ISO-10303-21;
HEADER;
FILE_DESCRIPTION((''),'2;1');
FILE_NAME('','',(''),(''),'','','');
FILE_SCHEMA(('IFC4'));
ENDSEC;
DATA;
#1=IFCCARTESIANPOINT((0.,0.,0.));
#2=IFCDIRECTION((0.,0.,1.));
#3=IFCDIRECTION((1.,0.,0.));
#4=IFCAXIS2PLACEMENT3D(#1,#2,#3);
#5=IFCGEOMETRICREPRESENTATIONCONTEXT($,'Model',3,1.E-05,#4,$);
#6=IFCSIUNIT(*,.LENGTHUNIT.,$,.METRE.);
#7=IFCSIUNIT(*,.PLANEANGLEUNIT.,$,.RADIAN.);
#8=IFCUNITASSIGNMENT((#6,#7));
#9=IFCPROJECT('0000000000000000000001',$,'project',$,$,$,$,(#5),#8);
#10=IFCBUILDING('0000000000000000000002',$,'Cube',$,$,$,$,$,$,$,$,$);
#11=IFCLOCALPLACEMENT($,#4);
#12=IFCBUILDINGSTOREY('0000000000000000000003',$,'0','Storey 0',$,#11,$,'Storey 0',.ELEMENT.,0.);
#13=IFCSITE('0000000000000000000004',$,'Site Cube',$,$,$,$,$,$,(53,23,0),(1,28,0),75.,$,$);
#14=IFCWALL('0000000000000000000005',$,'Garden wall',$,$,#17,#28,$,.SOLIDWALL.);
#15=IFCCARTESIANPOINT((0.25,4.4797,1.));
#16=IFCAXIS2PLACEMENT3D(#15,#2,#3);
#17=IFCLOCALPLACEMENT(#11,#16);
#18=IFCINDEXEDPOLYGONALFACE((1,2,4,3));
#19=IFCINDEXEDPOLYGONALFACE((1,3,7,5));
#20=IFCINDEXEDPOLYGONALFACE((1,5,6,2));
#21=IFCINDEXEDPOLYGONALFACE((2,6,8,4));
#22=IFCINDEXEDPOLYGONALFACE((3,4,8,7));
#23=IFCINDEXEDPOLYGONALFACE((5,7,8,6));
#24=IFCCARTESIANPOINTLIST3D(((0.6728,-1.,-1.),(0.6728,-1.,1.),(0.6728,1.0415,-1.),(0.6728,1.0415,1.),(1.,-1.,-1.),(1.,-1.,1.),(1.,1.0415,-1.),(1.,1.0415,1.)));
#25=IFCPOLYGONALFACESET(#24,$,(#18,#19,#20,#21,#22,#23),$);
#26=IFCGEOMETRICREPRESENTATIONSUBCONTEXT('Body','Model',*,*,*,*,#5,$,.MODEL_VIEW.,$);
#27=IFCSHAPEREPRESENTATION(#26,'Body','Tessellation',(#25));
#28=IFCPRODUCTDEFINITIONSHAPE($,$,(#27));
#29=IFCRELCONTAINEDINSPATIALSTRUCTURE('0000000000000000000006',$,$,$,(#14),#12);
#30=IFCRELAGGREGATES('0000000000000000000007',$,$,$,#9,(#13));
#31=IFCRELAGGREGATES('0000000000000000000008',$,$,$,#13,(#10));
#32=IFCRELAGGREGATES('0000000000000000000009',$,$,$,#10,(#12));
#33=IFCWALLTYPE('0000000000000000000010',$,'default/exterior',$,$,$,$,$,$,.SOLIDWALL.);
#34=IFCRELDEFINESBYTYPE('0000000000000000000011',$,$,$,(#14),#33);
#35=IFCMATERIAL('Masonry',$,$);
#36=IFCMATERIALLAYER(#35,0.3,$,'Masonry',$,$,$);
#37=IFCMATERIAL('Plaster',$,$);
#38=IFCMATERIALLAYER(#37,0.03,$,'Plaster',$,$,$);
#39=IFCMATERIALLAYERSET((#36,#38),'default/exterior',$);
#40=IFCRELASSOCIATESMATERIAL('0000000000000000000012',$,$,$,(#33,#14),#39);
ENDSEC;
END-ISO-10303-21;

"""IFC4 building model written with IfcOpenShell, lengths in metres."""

from ifc_helpers import new_model, si_unit, frame, origin_with_axes, place, context, subcontext, project, spatial, polyline, outline, extrude, material, layer, layer_set, layer_usage, type_object, element, save


model = new_model("IFC4")

# Units and contexts
model_context = context("Model", 3, precision=1e-05, world=origin_with_axes())
body_context = subcontext(model_context, "Body", "Model", "MODEL_VIEW")
ifc_project = project(units=[si_unit("LENGTHUNIT", "METRE"), si_unit("PLANEANGLEUNIT", "RADIAN")], contexts=[model_context])

# Site, building, storey
site = spatial("IfcSite", under=ifc_project, Name="Site Cube", RefLatitude=(53, 23, 0), RefLongitude=(1, 28, 0), RefElevation=75.0)
building = spatial("IfcBuilding", under=site, Name="Cube")
storey_placement = place(None, origin_with_axes())
storey = spatial("IfcBuildingStorey", under=building, at=storey_placement, Name="0", Description="Storey 0", LongName="Storey 0", CompositionType="ELEMENT", Elevation=0.0)

# Shared definitions
ifc_material_1 = material(Name="Masonry")
ifc_layer_1 = layer(ifc_material_1, 0.3, Name="Masonry")
ifc_material_2 = material(Name="Plaster")
ifc_layer_2 = layer(ifc_material_2, 0.03, Name="Plaster")
ifc_layer_set_1 = layer_set([ifc_layer_1, ifc_layer_2], Name="default/exterior")
wall_type = type_object("IfcWallType", Name="default/exterior", PredefinedType="SOLIDWALL", material=ifc_layer_set_1)

# Wall
ifc_layer_usage_1 = layer_usage(ifc_layer_set_1, "AXIS2", "POSITIVE", 0.0)
wall_1_placement = place(storey_placement, frame((0.25, 4.4797, 1.0), z_axis=(0.0, 0.0, 1.0), x_axis=(1.0, 0.0, 0.0)))
element("IfcWall", 1, at=wall_1_placement, inside=storey, type_object=wall_type, material=ifc_layer_usage_1, Name="Garden wall", PredefinedType="SOLIDWALL", context=body_context, shape_type="SweptSolid", body=[
    extrude(outline(polyline([(-0.1636, -1.0207), (0.1636, -1.0207), (0.1636, 1.0207), (-0.1636, 1.0207), (-0.1636, -1.0207)])), frame((0.8364, 0.0207, -1.0), z_axis=(0.0, 0.0, -1.0), x_axis=(-1.0, 0.0, 0.0)), (0.0, 0.0, -1.0), 2.0),
])

save(model, "model.ifc")
